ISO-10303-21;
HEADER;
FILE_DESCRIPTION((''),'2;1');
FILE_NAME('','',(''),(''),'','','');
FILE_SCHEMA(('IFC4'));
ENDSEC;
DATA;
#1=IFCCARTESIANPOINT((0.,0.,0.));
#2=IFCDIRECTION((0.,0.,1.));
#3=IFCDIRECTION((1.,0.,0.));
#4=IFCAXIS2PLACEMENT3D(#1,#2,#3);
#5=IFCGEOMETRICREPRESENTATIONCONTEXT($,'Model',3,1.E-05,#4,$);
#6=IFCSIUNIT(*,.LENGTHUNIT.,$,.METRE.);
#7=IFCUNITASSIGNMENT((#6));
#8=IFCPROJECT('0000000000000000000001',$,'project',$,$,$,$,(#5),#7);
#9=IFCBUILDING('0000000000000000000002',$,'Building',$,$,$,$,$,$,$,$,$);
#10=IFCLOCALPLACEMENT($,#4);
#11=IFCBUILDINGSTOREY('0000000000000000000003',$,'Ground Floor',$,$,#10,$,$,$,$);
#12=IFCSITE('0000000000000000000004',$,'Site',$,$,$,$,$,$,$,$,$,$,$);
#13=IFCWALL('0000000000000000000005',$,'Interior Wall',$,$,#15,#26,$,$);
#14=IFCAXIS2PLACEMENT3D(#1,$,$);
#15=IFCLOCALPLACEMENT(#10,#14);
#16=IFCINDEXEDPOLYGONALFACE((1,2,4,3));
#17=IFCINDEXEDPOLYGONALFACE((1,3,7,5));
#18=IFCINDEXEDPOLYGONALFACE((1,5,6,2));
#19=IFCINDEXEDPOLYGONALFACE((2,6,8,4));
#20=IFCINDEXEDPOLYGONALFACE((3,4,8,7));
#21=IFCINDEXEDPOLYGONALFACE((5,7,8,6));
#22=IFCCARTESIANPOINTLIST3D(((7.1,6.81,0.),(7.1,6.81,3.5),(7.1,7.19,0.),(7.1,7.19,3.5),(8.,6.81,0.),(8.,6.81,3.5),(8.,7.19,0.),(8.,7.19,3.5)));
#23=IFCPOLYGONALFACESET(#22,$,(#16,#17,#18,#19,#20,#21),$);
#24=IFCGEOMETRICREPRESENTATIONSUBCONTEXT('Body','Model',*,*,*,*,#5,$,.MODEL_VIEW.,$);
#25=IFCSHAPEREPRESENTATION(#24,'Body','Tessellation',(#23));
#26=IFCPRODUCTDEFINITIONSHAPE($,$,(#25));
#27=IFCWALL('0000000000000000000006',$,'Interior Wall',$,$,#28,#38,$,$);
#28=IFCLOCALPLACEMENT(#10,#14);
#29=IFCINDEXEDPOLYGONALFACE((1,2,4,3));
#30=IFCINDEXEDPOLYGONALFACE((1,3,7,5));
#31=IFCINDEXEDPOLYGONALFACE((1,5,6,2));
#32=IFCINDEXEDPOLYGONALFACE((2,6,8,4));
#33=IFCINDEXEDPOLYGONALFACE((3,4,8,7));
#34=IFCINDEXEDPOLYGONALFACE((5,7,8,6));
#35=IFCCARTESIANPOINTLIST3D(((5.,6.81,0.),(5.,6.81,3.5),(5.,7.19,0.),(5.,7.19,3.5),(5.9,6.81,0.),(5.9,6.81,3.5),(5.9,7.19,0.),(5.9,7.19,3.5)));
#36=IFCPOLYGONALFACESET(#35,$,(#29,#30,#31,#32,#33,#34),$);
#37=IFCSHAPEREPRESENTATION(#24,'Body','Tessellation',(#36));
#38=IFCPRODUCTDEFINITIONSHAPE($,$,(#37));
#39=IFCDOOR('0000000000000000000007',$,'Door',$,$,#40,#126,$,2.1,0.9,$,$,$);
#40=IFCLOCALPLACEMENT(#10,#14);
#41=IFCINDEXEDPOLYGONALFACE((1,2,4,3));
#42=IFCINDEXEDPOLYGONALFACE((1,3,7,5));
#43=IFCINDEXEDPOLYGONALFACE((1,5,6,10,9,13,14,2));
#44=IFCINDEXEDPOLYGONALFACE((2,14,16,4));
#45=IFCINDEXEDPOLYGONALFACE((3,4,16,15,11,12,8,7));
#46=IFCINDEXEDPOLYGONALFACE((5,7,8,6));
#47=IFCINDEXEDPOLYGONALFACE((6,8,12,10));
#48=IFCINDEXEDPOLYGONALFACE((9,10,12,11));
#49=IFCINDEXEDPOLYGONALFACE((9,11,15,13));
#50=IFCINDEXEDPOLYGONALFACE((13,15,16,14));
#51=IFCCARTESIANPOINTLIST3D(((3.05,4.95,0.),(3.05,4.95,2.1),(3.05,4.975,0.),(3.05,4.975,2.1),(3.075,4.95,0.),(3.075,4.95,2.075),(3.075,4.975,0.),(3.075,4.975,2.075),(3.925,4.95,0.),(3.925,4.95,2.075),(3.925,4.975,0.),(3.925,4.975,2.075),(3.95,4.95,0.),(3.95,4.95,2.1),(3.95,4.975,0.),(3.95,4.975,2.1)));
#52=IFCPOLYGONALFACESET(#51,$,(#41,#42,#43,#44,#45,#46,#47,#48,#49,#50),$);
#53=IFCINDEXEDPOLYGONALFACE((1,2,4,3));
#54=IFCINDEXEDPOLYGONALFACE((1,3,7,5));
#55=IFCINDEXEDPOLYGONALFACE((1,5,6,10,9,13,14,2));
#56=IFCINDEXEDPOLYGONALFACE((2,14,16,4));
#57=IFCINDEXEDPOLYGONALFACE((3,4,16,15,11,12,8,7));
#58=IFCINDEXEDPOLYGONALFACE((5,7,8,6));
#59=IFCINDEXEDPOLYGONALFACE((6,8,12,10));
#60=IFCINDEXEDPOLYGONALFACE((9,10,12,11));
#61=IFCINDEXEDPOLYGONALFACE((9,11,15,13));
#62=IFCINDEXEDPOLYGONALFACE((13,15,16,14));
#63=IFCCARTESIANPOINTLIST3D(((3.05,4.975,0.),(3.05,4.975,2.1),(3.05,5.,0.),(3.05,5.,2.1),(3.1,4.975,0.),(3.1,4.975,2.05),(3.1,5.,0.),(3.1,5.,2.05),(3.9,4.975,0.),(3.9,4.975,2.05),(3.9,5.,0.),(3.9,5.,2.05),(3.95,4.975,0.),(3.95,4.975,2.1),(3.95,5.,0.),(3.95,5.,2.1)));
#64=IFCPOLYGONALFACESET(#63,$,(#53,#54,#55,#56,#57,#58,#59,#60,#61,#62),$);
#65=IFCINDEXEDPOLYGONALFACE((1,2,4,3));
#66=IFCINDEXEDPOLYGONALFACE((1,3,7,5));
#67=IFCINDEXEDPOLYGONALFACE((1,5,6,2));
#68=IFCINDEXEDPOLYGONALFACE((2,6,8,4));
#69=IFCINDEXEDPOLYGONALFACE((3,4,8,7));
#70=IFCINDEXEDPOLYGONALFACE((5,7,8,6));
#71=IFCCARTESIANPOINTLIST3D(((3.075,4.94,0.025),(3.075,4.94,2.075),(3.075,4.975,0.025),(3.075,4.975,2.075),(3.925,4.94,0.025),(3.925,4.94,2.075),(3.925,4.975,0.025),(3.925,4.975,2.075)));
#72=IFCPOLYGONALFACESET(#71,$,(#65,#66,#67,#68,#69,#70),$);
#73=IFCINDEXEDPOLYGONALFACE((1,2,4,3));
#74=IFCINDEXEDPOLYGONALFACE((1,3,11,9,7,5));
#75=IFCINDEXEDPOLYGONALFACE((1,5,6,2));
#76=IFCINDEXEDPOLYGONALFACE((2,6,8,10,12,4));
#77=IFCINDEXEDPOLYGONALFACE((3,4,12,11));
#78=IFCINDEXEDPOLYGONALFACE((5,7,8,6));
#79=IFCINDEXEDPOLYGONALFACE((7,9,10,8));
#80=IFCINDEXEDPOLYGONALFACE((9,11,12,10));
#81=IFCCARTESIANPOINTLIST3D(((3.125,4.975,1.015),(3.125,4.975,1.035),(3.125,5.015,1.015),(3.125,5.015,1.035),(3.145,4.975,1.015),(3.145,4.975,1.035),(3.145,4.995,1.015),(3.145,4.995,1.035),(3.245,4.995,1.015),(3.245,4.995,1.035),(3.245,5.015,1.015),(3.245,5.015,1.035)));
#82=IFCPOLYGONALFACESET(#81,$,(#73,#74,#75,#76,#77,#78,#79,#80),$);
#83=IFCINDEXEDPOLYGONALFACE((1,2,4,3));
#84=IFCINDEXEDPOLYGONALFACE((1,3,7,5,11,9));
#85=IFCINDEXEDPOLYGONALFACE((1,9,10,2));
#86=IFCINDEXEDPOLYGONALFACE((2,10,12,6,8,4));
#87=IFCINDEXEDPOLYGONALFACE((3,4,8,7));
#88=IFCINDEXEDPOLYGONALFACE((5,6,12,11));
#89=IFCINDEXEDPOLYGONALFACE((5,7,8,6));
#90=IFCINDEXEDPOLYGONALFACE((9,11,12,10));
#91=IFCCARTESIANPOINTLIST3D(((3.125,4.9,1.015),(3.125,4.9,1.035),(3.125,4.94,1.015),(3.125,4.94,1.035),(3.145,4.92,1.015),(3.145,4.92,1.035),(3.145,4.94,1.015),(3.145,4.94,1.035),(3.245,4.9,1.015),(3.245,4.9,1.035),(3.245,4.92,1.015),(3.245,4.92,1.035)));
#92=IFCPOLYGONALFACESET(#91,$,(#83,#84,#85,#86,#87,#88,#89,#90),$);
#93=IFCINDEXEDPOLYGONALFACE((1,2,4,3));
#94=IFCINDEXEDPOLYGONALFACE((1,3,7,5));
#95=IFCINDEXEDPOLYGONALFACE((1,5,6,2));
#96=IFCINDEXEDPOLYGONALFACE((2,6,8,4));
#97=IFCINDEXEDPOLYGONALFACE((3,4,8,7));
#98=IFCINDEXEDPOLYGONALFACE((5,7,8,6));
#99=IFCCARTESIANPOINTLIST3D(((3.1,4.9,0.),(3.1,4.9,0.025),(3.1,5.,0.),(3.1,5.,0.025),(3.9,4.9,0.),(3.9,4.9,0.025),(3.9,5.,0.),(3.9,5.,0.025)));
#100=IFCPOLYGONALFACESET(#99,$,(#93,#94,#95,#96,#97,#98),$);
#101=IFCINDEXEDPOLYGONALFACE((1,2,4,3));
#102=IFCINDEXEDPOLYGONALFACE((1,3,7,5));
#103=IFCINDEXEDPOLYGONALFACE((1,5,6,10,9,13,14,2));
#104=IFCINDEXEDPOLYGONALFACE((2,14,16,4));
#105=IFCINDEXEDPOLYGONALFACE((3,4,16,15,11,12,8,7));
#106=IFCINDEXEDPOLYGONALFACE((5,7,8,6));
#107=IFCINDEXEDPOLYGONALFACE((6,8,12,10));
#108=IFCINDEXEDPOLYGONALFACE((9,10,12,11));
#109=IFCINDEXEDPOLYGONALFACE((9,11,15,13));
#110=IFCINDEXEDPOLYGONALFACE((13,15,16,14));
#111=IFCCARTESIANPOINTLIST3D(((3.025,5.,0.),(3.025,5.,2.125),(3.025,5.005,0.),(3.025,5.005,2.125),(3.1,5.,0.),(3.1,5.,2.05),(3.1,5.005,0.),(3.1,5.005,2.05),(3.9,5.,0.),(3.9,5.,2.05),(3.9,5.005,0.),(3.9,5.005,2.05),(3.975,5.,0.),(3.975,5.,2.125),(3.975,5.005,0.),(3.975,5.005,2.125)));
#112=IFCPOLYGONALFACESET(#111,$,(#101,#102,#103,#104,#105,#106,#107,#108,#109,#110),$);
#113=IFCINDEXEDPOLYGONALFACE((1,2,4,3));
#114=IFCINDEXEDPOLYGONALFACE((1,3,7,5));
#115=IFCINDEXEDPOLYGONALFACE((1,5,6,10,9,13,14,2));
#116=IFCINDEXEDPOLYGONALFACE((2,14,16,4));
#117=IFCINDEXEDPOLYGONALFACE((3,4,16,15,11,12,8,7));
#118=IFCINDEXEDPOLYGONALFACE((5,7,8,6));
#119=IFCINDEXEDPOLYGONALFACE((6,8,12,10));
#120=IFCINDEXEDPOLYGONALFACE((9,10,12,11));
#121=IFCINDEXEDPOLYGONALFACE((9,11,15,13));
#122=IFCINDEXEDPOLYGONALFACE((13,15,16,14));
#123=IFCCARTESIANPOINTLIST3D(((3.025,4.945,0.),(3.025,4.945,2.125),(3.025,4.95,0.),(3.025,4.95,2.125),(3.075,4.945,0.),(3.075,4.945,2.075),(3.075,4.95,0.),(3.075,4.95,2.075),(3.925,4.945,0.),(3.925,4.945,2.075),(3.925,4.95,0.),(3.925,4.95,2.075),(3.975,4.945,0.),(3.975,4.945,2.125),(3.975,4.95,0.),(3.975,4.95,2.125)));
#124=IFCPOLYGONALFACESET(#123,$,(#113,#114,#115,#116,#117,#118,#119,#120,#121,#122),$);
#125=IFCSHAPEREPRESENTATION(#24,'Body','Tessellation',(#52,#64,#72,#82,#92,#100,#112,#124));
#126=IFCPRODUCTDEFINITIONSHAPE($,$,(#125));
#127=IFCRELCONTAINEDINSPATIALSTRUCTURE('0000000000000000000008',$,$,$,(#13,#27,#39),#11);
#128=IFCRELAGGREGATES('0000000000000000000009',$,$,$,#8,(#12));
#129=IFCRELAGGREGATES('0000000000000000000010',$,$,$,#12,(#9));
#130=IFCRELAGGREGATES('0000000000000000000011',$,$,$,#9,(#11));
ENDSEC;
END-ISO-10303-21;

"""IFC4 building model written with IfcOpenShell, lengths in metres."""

from ifc_helpers import new_model, si_unit, frame, origin_with_axes, place, context, subcontext, project, spatial, line, indexed_curve, outline, extrude, element, save


model = new_model("IFC4")

# Units and contexts
model_context = context("Model", 3, precision=1e-05, world=origin_with_axes())
body_context = subcontext(model_context, "Body", "Model", "MODEL_VIEW")
ifc_project = project(units=[si_unit("LENGTHUNIT", "METRE")], contexts=[model_context])

# Site, building, storey
site = spatial("IfcSite", under=ifc_project, Name="Site")
building = spatial("IfcBuilding", under=site, Name="Building")
storey_placement = place(None, origin_with_axes())
storey = spatial("IfcBuildingStorey", under=building, at=storey_placement, Name="Ground Floor")

# Walls
for number, where, z_axis, x_axis, name in (
    (1, (8.0, 7.0, 0.0), (0.0, 0.0, 1.0), (-1.0, 0.0, 0.0), "Interior Wall"),
    (2, (5.9, 7.0, 0.0), (0.0, 0.0, 1.0), (-1.0, 0.0, 0.0), "Interior Wall"),
):
    element("IfcWall", number, at=place(storey_placement, frame(where, z_axis=z_axis, x_axis=x_axis)), inside=storey, Name=name, context=body_context, shape_type="SweptSolid", body=[
        extrude(outline(indexed_curve([(0.0, 0.0), (0.0, 0.38), (0.9, 0.38), (0.9, 0.0), (0.0, 0.0)], self_intersect=False)), frame((0.0, -0.19, 0.0), z_axis=(0.0, 0.0, 1.0), x_axis=(1.0, 0.0, 0.0)), (0.0, 0.0, 1.0), 3.5),
    ])

# Door
door_1_placement = place(storey_placement, frame((3.95, 5.0, 0.0), z_axis=(0.0, 0.0, 1.0), x_axis=(-1.0, 0.0, 0.0)))
element("IfcDoor", 3, at=door_1_placement, inside=storey, Name="Door", OverallHeight=2.1, OverallWidth=0.9, context=body_context, shape_type="SweptSolid", body=[
    extrude(outline(indexed_curve([(0.0, 0.0), (0.0, 2.1), (0.9, 2.1), (0.9, 0.0), (0.875, 0.0), (0.875, 2.075), (0.025, 2.075), (0.025, 0.0)], segments=[line(1, 2, 3, 4, 5, 6, 7, 8, 1)])), frame((0.0, 0.025, 0.0), z_axis=(0.0, -1.0, 0.0), x_axis=(1.0, 0.0, 0.0)), (0.0, 0.0, -1.0), 0.025),
    extrude(outline(indexed_curve([(0.0, 0.0), (0.0, 2.1), (0.9, 2.1), (0.9, 0.0), (0.85, 0.0), (0.85, 2.05), (0.05, 2.05), (0.05, 0.0)], segments=[line(1, 2, 3, 4, 5, 6, 7, 8, 1)])), frame((0.0, 0.0, 0.0), z_axis=(0.0, -1.0, 0.0), x_axis=(1.0, 0.0, 0.0)), (0.0, 0.0, -1.0), 0.025),
    extrude(outline(indexed_curve([(0.0, 0.0), (0.85, 0.0), (0.85, 0.035), (0.0, 0.035)], segments=[line(1, 2, 3, 4, 1)])), frame((0.025, 0.025, 0.025), z_axis=(0.0, 0.0, 1.0), x_axis=(1.0, 0.0, 0.0)), (0.0, 0.0, 1.0), 2.05),
    extrude(outline(indexed_curve([(0.0, 0.0), (0.0, -0.04), (-0.12, -0.04), (-0.12, -0.02), (-0.02, -0.02), (-0.02, 0.0)], segments=[line(1, 2, 3, 4, 5, 6, 1)])), frame((0.825, 0.025, 1.015), z_axis=(0.0, 0.0, 1.0), x_axis=(1.0, 0.0, 0.0)), (0.0, 0.0, 1.0), 0.02),
    extrude(outline(indexed_curve([(0.0, 0.0), (0.0, 0.04), (-0.12, 0.04), (-0.12, 0.02), (-0.02, 0.02), (-0.02, 0.0)], segments=[line(1, 2, 3, 4, 5, 6, 1)])), frame((0.825, 0.06, 1.015), z_axis=(0.0, 0.0, 1.0), x_axis=(1.0, 0.0, 0.0)), (0.0, 0.0, 1.0), 0.02),
    extrude(outline(indexed_curve([(0.0, 0.0), (0.8, 0.0), (0.8, 0.1), (0.0, 0.1)], segments=[line(1, 2, 3, 4, 1)])), frame((0.05, 0.0, 0.0), z_axis=(0.0, 0.0, 1.0), x_axis=(1.0, 0.0, 0.0)), (0.0, 0.0, 1.0), 0.025),
    extrude(outline(indexed_curve([(0.0, 0.0), (0.0, 2.125), (0.95, 2.125), (0.95, 0.0), (0.875, 0.0), (0.875, 2.05), (0.075, 2.05), (0.075, 0.0)], segments=[line(1, 2, 3, 4, 5, 6, 7, 8, 1)])), frame((-0.025, -0.005, 0.0), z_axis=(0.0, -1.0, 0.0), x_axis=(1.0, 0.0, 0.0)), (0.0, 0.0, -1.0), 0.005),
    extrude(outline(indexed_curve([(0.0, 0.0), (0.0, 2.125), (0.95, 2.125), (0.95, 0.0), (0.9, 0.0), (0.9, 2.075), (0.05, 2.075), (0.05, 0.0)], segments=[line(1, 2, 3, 4, 5, 6, 7, 8, 1)])), frame((-0.025, 0.05, 0.0), z_axis=(0.0, -1.0, 0.0), x_axis=(1.0, 0.0, 0.0)), (0.0, 0.0, -1.0), 0.005),
])

save(model, "model.ifc")
